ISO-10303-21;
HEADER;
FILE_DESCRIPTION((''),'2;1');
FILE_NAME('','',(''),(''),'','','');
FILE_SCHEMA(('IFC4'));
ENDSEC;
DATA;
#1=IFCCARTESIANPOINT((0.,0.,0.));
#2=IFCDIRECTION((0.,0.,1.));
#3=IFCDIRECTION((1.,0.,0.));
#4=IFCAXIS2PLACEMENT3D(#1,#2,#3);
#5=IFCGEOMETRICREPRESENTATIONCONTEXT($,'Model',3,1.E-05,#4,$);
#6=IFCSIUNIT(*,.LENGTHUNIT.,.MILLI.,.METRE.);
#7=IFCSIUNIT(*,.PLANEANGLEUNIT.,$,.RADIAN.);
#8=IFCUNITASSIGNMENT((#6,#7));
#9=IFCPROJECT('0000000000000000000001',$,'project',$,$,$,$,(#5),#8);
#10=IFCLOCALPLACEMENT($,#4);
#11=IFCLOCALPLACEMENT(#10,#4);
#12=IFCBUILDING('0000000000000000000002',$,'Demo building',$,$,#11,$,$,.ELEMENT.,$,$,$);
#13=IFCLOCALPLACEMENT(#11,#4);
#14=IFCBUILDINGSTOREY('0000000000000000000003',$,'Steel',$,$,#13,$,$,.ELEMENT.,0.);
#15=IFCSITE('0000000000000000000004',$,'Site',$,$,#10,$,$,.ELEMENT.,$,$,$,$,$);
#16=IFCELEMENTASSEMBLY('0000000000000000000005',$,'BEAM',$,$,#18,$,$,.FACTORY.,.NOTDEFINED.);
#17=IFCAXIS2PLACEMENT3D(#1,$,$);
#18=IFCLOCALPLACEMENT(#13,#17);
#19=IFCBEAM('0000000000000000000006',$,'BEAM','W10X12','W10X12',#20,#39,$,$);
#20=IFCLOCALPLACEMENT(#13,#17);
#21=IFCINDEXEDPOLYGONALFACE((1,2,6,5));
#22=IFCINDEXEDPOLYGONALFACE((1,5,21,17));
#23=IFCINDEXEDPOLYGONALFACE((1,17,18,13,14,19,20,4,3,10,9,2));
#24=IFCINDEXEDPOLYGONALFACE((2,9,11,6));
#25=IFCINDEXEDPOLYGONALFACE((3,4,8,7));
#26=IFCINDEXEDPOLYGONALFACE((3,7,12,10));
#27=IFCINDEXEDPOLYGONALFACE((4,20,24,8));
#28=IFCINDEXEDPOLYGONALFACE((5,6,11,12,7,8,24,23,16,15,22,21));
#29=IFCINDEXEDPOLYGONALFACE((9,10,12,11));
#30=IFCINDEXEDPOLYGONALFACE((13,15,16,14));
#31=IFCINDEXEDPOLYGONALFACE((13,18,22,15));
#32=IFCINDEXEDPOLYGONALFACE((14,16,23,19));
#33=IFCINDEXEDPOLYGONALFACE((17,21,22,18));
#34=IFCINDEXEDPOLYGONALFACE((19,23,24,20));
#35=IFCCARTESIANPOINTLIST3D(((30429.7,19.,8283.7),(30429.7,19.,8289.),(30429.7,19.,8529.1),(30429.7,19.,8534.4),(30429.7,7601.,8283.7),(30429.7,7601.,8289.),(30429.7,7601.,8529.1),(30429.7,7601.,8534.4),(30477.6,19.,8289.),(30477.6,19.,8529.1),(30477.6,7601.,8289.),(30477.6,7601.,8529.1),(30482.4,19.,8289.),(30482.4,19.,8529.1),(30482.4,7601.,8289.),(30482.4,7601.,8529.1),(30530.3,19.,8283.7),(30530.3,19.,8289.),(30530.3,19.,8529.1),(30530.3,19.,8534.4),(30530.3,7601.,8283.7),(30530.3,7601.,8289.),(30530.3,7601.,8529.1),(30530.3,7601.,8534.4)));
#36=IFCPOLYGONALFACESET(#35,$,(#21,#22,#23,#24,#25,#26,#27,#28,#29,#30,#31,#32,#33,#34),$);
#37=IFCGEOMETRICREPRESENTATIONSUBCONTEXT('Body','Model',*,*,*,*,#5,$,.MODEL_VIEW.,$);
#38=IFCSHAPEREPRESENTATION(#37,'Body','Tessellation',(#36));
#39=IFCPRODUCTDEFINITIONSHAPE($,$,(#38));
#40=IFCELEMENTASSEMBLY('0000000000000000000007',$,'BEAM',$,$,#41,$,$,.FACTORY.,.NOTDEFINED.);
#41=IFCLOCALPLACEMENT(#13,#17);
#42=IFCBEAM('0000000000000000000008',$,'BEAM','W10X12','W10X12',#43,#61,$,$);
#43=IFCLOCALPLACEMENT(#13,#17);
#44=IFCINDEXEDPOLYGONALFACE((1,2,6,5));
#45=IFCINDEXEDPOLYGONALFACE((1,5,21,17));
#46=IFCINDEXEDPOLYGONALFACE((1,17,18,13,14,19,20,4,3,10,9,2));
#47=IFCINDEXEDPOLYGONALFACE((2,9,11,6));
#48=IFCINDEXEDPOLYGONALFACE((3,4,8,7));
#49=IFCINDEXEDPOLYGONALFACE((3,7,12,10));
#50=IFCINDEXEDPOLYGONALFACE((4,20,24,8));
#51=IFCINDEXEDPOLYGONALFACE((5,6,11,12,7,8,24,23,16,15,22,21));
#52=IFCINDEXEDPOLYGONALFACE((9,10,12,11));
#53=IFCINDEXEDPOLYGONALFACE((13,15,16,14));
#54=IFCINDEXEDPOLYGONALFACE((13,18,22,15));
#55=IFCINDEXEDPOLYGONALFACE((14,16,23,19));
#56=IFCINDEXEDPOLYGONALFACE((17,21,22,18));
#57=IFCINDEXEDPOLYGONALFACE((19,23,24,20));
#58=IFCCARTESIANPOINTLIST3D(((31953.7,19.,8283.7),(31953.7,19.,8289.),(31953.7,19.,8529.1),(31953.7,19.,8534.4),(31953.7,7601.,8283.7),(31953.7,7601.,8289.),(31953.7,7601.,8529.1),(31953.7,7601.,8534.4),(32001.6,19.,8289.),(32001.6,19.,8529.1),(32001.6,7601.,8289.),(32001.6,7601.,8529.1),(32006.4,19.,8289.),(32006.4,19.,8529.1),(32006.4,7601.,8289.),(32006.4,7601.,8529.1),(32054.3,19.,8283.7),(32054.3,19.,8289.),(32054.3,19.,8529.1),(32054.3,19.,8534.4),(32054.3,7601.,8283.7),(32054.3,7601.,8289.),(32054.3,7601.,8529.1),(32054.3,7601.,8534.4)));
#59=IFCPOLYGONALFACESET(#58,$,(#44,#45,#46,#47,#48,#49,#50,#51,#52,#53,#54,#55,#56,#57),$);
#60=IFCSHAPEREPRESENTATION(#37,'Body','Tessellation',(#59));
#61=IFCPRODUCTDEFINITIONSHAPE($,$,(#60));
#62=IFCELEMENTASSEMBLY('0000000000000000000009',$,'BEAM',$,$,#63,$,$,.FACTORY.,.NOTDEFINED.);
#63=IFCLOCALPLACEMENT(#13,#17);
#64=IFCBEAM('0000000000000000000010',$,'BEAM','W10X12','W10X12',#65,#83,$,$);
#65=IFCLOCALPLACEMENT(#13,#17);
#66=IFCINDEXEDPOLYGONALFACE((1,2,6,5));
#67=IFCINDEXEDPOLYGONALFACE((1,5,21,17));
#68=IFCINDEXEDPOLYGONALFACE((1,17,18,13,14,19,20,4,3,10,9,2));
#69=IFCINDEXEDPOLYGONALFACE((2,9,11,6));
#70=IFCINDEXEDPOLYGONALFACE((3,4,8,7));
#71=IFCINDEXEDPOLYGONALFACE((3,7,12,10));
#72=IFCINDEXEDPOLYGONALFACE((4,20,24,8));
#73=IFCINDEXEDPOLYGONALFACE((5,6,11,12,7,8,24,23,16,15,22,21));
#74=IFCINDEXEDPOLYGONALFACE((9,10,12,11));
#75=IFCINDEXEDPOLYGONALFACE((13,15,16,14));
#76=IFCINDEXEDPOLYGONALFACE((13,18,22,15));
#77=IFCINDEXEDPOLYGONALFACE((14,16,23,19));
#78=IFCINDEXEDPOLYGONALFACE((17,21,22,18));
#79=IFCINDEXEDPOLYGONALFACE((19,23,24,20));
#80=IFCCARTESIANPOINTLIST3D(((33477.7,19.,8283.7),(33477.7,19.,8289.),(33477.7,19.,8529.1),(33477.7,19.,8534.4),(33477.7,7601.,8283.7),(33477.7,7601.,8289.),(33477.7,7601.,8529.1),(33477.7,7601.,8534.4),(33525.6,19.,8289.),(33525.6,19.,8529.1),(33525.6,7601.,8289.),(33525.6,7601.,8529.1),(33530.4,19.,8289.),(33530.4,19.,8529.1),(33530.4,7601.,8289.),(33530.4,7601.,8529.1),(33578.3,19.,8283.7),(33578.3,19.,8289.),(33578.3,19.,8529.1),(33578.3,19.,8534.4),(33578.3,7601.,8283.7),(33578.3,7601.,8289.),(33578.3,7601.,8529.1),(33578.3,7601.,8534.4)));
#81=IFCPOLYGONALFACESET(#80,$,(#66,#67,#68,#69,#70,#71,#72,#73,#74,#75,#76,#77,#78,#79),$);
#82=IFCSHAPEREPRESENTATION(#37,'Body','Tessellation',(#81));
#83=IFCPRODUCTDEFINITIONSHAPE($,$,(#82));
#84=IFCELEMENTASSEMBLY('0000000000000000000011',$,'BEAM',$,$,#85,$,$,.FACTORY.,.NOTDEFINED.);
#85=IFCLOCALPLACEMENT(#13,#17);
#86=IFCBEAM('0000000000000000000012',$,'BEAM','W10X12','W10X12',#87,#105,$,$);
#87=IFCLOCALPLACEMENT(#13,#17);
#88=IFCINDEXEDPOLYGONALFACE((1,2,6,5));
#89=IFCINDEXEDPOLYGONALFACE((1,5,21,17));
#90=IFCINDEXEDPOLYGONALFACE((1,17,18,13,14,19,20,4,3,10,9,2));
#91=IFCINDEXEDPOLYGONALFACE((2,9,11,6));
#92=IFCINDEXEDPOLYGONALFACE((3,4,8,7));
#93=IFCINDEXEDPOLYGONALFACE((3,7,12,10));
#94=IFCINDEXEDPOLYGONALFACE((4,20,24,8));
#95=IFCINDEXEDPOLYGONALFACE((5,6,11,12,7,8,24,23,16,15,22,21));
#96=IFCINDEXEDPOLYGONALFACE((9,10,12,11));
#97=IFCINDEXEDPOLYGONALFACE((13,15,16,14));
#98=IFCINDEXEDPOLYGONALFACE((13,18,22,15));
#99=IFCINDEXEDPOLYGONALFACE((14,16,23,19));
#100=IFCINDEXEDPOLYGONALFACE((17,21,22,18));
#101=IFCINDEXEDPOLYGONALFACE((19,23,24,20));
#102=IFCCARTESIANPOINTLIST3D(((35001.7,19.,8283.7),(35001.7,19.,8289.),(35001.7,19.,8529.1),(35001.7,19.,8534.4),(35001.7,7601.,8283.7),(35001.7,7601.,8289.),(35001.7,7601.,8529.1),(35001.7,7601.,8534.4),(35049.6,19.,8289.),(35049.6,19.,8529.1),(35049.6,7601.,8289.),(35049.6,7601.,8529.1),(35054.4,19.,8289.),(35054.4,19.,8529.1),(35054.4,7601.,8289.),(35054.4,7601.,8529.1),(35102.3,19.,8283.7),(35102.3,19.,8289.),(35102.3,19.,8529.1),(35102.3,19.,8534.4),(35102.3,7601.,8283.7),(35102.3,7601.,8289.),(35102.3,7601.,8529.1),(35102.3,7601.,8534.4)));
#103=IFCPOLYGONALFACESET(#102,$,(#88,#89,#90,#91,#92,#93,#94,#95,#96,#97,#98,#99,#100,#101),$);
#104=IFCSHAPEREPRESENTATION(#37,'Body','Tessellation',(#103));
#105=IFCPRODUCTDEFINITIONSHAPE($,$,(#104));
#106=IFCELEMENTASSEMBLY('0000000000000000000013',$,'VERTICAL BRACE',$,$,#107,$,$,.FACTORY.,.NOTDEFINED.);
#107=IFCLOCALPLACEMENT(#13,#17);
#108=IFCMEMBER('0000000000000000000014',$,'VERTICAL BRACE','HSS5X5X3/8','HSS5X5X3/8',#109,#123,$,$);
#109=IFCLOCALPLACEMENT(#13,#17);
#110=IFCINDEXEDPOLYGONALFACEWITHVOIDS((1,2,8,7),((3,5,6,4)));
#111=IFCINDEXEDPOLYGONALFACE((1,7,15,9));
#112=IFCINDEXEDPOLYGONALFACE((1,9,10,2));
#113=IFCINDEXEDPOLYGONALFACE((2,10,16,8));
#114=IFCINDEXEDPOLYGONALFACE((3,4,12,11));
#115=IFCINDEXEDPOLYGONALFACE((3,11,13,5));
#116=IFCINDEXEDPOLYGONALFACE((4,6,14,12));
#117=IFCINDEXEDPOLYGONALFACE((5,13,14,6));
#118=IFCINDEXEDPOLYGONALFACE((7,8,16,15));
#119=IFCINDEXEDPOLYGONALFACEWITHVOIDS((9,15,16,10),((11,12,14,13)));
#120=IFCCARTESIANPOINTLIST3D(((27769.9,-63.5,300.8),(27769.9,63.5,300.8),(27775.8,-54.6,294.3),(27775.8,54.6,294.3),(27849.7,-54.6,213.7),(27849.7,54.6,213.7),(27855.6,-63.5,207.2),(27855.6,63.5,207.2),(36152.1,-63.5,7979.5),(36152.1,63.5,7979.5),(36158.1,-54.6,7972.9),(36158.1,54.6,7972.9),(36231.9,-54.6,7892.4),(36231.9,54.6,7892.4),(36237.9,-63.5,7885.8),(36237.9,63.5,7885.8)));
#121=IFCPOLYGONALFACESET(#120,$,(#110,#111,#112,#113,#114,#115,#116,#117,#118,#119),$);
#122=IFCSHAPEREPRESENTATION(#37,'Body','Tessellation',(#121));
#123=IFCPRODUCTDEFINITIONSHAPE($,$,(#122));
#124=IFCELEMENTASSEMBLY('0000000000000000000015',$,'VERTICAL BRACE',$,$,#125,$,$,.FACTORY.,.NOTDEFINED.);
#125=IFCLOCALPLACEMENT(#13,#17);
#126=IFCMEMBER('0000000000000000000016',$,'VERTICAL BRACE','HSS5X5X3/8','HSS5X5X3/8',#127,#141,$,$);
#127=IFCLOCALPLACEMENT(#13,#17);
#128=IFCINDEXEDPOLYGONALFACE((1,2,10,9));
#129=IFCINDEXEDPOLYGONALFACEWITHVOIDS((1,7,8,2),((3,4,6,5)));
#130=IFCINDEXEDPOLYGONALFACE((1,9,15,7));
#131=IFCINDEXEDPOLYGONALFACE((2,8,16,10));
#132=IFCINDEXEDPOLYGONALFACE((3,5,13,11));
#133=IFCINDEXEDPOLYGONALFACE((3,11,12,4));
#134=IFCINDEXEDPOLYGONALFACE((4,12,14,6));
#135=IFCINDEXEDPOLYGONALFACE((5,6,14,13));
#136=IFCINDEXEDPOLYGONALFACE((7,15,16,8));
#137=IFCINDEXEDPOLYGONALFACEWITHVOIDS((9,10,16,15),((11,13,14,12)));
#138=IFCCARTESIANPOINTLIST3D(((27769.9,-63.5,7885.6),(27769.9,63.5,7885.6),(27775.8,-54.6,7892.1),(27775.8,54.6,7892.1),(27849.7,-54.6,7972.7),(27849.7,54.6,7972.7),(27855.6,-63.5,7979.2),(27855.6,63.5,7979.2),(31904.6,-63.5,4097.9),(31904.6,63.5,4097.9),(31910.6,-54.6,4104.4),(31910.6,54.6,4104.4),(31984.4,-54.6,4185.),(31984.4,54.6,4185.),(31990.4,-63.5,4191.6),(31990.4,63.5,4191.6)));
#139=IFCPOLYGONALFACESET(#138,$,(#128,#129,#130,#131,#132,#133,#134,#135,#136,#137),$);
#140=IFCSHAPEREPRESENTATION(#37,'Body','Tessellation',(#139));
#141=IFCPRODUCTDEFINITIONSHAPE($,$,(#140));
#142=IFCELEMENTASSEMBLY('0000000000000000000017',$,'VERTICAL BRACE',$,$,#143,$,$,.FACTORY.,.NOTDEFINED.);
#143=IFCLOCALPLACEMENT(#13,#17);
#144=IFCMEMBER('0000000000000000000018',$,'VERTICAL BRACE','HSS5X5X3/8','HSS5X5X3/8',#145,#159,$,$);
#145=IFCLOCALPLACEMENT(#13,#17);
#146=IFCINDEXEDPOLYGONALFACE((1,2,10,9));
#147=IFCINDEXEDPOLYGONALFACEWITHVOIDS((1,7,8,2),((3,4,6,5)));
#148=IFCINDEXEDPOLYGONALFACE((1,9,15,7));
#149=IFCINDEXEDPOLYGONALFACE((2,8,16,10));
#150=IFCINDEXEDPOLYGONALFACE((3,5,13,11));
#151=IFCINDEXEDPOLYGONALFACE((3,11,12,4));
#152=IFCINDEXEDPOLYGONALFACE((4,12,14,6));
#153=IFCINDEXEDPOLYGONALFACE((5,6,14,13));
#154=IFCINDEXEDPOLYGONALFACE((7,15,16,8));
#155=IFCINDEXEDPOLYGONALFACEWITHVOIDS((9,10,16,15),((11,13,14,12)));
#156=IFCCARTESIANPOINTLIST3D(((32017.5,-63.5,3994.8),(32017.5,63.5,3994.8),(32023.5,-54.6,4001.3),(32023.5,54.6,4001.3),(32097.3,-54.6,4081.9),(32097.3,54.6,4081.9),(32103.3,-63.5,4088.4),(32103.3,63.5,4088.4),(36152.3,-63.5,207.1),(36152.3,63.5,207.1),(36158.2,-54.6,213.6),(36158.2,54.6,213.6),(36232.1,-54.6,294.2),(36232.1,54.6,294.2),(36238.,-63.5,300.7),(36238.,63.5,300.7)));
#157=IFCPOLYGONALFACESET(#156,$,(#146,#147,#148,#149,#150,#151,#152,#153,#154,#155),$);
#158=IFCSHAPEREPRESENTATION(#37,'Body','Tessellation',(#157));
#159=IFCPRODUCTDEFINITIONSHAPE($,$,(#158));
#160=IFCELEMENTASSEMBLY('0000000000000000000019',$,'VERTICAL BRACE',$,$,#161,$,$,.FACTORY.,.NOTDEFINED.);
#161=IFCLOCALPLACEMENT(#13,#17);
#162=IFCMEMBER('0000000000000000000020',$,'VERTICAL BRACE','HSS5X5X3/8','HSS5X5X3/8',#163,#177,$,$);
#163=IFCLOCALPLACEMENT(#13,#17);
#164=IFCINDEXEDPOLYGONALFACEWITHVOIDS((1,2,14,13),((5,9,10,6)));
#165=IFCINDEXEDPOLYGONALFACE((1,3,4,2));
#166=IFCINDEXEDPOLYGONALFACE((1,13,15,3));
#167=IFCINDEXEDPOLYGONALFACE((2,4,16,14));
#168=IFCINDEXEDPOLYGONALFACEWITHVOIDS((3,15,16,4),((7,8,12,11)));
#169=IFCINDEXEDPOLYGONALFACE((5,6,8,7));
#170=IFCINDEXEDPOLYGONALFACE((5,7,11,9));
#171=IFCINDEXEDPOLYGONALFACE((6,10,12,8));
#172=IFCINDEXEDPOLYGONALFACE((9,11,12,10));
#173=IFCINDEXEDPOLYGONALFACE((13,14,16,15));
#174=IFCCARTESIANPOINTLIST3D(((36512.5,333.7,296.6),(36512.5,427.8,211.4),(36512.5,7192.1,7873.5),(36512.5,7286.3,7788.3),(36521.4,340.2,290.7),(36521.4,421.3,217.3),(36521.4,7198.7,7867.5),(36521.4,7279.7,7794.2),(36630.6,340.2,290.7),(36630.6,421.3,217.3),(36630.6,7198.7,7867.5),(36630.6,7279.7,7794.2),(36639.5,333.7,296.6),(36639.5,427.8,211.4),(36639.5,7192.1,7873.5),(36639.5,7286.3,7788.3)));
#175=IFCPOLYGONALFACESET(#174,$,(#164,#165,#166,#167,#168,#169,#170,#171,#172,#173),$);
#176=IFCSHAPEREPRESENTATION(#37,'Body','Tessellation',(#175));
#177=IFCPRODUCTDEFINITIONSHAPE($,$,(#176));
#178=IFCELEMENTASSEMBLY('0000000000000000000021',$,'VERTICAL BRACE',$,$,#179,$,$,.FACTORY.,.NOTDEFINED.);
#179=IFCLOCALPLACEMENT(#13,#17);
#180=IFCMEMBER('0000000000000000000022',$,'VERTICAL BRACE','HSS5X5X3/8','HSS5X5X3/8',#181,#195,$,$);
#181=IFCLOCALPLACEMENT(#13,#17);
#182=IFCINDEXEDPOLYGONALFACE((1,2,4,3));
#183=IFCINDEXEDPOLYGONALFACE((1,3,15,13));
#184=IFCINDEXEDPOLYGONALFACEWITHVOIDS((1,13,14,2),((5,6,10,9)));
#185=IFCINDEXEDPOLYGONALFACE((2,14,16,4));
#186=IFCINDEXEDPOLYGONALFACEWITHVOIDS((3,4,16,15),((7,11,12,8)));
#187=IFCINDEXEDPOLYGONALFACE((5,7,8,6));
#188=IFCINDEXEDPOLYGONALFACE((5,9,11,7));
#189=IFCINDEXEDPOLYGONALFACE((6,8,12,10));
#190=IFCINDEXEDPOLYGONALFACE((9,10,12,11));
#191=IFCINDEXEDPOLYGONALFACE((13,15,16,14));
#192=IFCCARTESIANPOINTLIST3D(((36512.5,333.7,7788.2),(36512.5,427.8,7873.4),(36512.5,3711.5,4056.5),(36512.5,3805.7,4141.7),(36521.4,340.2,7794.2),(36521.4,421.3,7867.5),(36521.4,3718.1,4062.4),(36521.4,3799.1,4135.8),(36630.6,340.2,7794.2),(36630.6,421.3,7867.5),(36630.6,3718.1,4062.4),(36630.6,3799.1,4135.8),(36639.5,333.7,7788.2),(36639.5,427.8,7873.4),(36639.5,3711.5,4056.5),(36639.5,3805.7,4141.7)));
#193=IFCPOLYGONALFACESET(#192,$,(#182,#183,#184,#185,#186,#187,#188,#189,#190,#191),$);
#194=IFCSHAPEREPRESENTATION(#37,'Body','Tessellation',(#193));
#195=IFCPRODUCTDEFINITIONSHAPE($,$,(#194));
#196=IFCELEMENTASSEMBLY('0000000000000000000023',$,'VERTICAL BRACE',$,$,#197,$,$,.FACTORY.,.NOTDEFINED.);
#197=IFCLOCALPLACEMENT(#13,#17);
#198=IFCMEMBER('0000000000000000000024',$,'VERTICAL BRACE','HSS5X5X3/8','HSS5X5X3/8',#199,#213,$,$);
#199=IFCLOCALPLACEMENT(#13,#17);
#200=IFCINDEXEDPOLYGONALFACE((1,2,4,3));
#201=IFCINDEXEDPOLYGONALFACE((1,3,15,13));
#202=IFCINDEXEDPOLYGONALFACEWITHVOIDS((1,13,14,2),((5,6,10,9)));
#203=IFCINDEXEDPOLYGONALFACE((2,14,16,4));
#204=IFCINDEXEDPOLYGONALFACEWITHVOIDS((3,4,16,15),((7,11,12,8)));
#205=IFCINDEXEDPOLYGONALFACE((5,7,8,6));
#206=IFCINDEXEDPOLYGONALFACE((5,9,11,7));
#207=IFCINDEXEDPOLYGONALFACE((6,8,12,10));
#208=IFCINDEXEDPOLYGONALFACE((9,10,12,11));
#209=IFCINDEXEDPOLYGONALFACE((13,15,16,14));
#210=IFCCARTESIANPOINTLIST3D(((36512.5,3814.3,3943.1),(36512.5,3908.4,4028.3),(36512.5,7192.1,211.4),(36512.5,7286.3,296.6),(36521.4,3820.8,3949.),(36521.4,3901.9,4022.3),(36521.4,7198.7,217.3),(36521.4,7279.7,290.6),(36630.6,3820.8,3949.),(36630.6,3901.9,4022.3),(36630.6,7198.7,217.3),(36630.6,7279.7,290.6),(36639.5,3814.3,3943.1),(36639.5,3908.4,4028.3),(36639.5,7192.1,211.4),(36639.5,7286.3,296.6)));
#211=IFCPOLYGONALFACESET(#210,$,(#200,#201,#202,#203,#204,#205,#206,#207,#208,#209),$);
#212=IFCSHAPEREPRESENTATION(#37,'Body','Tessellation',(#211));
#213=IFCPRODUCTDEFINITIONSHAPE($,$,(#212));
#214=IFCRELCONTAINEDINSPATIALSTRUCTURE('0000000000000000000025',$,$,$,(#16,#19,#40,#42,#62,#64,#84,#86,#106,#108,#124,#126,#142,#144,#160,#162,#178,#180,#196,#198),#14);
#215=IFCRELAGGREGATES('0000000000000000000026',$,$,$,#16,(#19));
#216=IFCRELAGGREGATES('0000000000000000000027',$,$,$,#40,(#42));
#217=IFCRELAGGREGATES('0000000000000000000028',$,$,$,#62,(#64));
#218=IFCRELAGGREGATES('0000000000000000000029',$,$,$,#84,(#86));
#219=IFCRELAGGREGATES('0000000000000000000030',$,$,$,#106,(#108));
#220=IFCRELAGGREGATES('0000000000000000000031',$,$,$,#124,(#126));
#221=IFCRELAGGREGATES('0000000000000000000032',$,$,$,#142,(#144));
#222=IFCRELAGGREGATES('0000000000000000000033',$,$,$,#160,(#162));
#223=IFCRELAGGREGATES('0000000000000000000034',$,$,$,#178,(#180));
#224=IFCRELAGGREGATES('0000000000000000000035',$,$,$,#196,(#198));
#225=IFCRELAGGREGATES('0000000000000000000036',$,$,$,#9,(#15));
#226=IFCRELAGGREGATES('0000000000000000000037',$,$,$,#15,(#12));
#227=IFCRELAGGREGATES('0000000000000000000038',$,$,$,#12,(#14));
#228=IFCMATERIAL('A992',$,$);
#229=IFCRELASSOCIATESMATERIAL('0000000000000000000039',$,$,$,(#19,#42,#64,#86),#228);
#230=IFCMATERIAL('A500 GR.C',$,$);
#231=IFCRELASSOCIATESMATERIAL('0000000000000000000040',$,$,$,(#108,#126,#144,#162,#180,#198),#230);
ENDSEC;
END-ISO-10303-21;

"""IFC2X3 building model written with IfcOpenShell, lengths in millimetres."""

from ifc_helpers import new_model, si_unit, frame, origin, origin_with_axes, origin_2d, place, context, subcontext, project, spatial, hollow_rectangle, i_section, extrude, material, element, aggregate, save


model = new_model("IFC2X3")

# Units and contexts
model_context = context("Model", 3, precision=1e-05, world=origin_with_axes())
body_context = subcontext(model_context, "Body", "Model", "MODEL_VIEW")
ifc_project = project(units=[si_unit("LENGTHUNIT", "METRE", prefix="MILLI"), si_unit("PLANEANGLEUNIT", "RADIAN")], contexts=[model_context])

# Site, building, storey
site_placement = place(None, origin_with_axes())
site = spatial("IfcSite", under=ifc_project, at=site_placement, Name="Site", CompositionType="ELEMENT")
building_placement = place(site_placement, origin_with_axes())
building = spatial("IfcBuilding", under=site, at=building_placement, Name="Demo building", CompositionType="ELEMENT")
placement = place(building_placement, origin_with_axes())
storey = spatial("IfcBuildingStorey", under=building, at=placement, Name="Steel", CompositionType="ELEMENT", Elevation=0.0)

# Shared definitions
ifc_material_1 = material(Name="A992")

# Element assemblies, beams
assembly_1 = element("IfcElementAssembly", 1, at=placement, inside=storey, Name="BEAM", AssemblyPlace="FACTORY", PredefinedType="NOTDEFINED")
beam_1_placement = place(placement, frame((30480.0, 19.1, 8409.1), z_axis=(0.0, 1.0, 0.0), x_axis=(-1.0, 0.0, 0.0)))
beam_1 = element("IfcBeam", 2, at=beam_1_placement, inside=storey, material=ifc_material_1, Name="BEAM", Description="W10X12", ObjectType="W10X12", context=body_context, shape_type="SweptSolid", body=[
    extrude(i_section(OverallWidth=100.6, OverallDepth=250.7, WebThickness=4.8, FlangeThickness=5.3, at=origin_2d()), origin(), (0.0, 0.0, 1.0), 7581.9),
])
aggregate(assembly_1, [beam_1])
assembly_2 = element("IfcElementAssembly", 3, at=placement, inside=storey, Name="BEAM", AssemblyPlace="FACTORY", PredefinedType="NOTDEFINED")
beam_2_placement = place(placement, frame((32004.0, 19.1, 8409.1), z_axis=(0.0, 1.0, 0.0), x_axis=(-1.0, 0.0, 0.0)))
beam_2 = element("IfcBeam", 4, at=beam_2_placement, inside=storey, material=ifc_material_1, Name="BEAM", Description="W10X12", ObjectType="W10X12", context=body_context, shape_type="SweptSolid", body=[
    extrude(i_section(OverallWidth=100.6, OverallDepth=250.7, WebThickness=4.8, FlangeThickness=5.3, at=origin_2d()), origin(), (0.0, 0.0, 1.0), 7581.9),
])
aggregate(assembly_2, [beam_2])
assembly_3 = element("IfcElementAssembly", 5, at=placement, inside=storey, Name="BEAM", AssemblyPlace="FACTORY", PredefinedType="NOTDEFINED")
beam_3_placement = place(placement, frame((33528.0, 19.1, 8409.1), z_axis=(0.0, 1.0, 0.0), x_axis=(-1.0, 0.0, 0.0)))
beam_3 = element("IfcBeam", 6, at=beam_3_placement, inside=storey, material=ifc_material_1, Name="BEAM", Description="W10X12", ObjectType="W10X12", context=body_context, shape_type="SweptSolid", body=[
    extrude(i_section(OverallWidth=100.6, OverallDepth=250.7, WebThickness=4.8, FlangeThickness=5.3, at=origin_2d()), origin(), (0.0, 0.0, 1.0), 7581.9),
])
aggregate(assembly_3, [beam_3])
assembly_4 = element("IfcElementAssembly", 7, at=placement, inside=storey, Name="BEAM", AssemblyPlace="FACTORY", PredefinedType="NOTDEFINED")
beam_4_placement = place(placement, frame((35052.0, 19.1, 8409.1), z_axis=(0.0, 1.0, 0.0), x_axis=(-1.0, 0.0, 0.0)))
beam_4 = element("IfcBeam", 8, at=beam_4_placement, inside=storey, material=ifc_material_1, Name="BEAM", Description="W10X12", ObjectType="W10X12", context=body_context, shape_type="SweptSolid", body=[
    extrude(i_section(OverallWidth=100.6, OverallDepth=250.7, WebThickness=4.8, FlangeThickness=5.3, at=origin_2d()), origin(), (0.0, 0.0, 1.0), 7581.9),
])
aggregate(assembly_4, [beam_4])

# Element assemblies, members
assembly_5 = element("IfcElementAssembly", 9, at=placement, inside=storey, Name="VERTICAL BRACE", AssemblyPlace="FACTORY", PredefinedType="NOTDEFINED")
ifc_material_2 = material(Name="A500 GR.C")
member_1_placement = place(placement, frame((27812.7, 0.0, 254.0), z_axis=(0.7374, 0.0, 0.6755), x_axis=(0.0, 1.0, 0.0)))
member_1 = element("IfcMember", 10, at=member_1_placement, inside=storey, material=ifc_material_2, Name="VERTICAL BRACE", Description="HSS5X5X3/8", ObjectType="HSS5X5X3/8", context=body_context, shape_type="SweptSolid", body=[
    extrude(hollow_rectangle(XDim=127.0, YDim=127.0, WallThickness=8.9, at=origin_2d()), origin(), (0.0, 0.0, 1.0), 11367.7),
])
aggregate(assembly_5, [member_1])
assembly_6 = element("IfcElementAssembly", 11, at=placement, inside=storey, Name="VERTICAL BRACE", AssemblyPlace="FACTORY", PredefinedType="NOTDEFINED")
member_2_placement = place(placement, frame((27812.7, 0.0, 7932.4), z_axis=(0.7374, 0.0, -0.6755), x_axis=(0.0, 1.0, 0.0)))
member_2 = element("IfcMember", 12, at=member_2_placement, inside=storey, material=ifc_material_2, Name="VERTICAL BRACE", Description="HSS5X5X3/8", ObjectType="HSS5X5X3/8", context=body_context, shape_type="SweptSolid", body=[
    extrude(hollow_rectangle(XDim=127.0, YDim=127.0, WallThickness=8.9, at=origin_2d()), origin(), (0.0, 0.0, 1.0), 5607.4),
])
aggregate(assembly_6, [member_2])
assembly_7 = element("IfcElementAssembly", 13, at=placement, inside=storey, Name="VERTICAL BRACE", AssemblyPlace="FACTORY", PredefinedType="NOTDEFINED")
member_3_placement = place(placement, frame((32060.4, 0.0, 4041.6), z_axis=(0.7374, 0.0, -0.6755), x_axis=(0.0, 1.0, 0.0)))
member_3 = element("IfcMember", 14, at=member_3_placement, inside=storey, material=ifc_material_2, Name="VERTICAL BRACE", Description="HSS5X5X3/8", ObjectType="HSS5X5X3/8", context=body_context, shape_type="SweptSolid", body=[
    extrude(hollow_rectangle(XDim=127.0, YDim=127.0, WallThickness=8.9, at=origin_2d()), origin(), (0.0, 0.0, 1.0), 5607.4),
])
aggregate(assembly_7, [member_3])
assembly_8 = element("IfcElementAssembly", 15, at=placement, inside=storey, Name="VERTICAL BRACE", AssemblyPlace="FACTORY", PredefinedType="NOTDEFINED")
member_4_placement = place(placement, frame((36576.0, 380.7, 254.0), z_axis=(0.0, 0.6711, 0.7414), x_axis=(-1.0, 0.0, 0.0)))
member_4 = element("IfcMember", 16, at=member_4_placement, inside=storey, material=ifc_material_2, Name="VERTICAL BRACE", Description="HSS5X5X3/8", ObjectType="HSS5X5X3/8", context=body_context, shape_type="SweptSolid", body=[
    extrude(hollow_rectangle(XDim=127.0, YDim=127.0, WallThickness=8.9, at=origin_2d()), origin(), (0.0, 0.0, 1.0), 10219.9),
])
aggregate(assembly_8, [member_4])
assembly_9 = element("IfcElementAssembly", 17, at=placement, inside=storey, Name="VERTICAL BRACE", AssemblyPlace="FACTORY", PredefinedType="NOTDEFINED")
member_5_placement = place(placement, frame((36576.0, 380.7, 7830.8), z_axis=(0.0, 0.6711, -0.7414), x_axis=(-1.0, 0.0, 0.0)))
member_5 = element("IfcMember", 18, at=member_5_placement, inside=storey, material=ifc_material_2, Name="VERTICAL BRACE", Description="HSS5X5X3/8", ObjectType="HSS5X5X3/8", context=body_context, shape_type="SweptSolid", body=[
    extrude(hollow_rectangle(XDim=127.0, YDim=127.0, WallThickness=8.9, at=origin_2d()), origin(), (0.0, 0.0, 1.0), 5033.5),
])
aggregate(assembly_9, [member_5])
assembly_10 = element("IfcElementAssembly", 19, at=placement, inside=storey, Name="VERTICAL BRACE", AssemblyPlace="FACTORY", PredefinedType="NOTDEFINED")
member_6_placement = place(placement, frame((36576.0, 3861.3, 3985.7), z_axis=(0.0, 0.6711, -0.7414), x_axis=(-1.0, 0.0, 0.0)))
member_6 = element("IfcMember", 20, at=member_6_placement, inside=storey, material=ifc_material_2, Name="VERTICAL BRACE", Description="HSS5X5X3/8", ObjectType="HSS5X5X3/8", context=body_context, shape_type="SweptSolid", body=[
    extrude(hollow_rectangle(XDim=127.0, YDim=127.0, WallThickness=8.9, at=origin_2d()), origin(), (0.0, 0.0, 1.0), 5033.5),
])
aggregate(assembly_10, [member_6])

save(model, "model.ifc")
